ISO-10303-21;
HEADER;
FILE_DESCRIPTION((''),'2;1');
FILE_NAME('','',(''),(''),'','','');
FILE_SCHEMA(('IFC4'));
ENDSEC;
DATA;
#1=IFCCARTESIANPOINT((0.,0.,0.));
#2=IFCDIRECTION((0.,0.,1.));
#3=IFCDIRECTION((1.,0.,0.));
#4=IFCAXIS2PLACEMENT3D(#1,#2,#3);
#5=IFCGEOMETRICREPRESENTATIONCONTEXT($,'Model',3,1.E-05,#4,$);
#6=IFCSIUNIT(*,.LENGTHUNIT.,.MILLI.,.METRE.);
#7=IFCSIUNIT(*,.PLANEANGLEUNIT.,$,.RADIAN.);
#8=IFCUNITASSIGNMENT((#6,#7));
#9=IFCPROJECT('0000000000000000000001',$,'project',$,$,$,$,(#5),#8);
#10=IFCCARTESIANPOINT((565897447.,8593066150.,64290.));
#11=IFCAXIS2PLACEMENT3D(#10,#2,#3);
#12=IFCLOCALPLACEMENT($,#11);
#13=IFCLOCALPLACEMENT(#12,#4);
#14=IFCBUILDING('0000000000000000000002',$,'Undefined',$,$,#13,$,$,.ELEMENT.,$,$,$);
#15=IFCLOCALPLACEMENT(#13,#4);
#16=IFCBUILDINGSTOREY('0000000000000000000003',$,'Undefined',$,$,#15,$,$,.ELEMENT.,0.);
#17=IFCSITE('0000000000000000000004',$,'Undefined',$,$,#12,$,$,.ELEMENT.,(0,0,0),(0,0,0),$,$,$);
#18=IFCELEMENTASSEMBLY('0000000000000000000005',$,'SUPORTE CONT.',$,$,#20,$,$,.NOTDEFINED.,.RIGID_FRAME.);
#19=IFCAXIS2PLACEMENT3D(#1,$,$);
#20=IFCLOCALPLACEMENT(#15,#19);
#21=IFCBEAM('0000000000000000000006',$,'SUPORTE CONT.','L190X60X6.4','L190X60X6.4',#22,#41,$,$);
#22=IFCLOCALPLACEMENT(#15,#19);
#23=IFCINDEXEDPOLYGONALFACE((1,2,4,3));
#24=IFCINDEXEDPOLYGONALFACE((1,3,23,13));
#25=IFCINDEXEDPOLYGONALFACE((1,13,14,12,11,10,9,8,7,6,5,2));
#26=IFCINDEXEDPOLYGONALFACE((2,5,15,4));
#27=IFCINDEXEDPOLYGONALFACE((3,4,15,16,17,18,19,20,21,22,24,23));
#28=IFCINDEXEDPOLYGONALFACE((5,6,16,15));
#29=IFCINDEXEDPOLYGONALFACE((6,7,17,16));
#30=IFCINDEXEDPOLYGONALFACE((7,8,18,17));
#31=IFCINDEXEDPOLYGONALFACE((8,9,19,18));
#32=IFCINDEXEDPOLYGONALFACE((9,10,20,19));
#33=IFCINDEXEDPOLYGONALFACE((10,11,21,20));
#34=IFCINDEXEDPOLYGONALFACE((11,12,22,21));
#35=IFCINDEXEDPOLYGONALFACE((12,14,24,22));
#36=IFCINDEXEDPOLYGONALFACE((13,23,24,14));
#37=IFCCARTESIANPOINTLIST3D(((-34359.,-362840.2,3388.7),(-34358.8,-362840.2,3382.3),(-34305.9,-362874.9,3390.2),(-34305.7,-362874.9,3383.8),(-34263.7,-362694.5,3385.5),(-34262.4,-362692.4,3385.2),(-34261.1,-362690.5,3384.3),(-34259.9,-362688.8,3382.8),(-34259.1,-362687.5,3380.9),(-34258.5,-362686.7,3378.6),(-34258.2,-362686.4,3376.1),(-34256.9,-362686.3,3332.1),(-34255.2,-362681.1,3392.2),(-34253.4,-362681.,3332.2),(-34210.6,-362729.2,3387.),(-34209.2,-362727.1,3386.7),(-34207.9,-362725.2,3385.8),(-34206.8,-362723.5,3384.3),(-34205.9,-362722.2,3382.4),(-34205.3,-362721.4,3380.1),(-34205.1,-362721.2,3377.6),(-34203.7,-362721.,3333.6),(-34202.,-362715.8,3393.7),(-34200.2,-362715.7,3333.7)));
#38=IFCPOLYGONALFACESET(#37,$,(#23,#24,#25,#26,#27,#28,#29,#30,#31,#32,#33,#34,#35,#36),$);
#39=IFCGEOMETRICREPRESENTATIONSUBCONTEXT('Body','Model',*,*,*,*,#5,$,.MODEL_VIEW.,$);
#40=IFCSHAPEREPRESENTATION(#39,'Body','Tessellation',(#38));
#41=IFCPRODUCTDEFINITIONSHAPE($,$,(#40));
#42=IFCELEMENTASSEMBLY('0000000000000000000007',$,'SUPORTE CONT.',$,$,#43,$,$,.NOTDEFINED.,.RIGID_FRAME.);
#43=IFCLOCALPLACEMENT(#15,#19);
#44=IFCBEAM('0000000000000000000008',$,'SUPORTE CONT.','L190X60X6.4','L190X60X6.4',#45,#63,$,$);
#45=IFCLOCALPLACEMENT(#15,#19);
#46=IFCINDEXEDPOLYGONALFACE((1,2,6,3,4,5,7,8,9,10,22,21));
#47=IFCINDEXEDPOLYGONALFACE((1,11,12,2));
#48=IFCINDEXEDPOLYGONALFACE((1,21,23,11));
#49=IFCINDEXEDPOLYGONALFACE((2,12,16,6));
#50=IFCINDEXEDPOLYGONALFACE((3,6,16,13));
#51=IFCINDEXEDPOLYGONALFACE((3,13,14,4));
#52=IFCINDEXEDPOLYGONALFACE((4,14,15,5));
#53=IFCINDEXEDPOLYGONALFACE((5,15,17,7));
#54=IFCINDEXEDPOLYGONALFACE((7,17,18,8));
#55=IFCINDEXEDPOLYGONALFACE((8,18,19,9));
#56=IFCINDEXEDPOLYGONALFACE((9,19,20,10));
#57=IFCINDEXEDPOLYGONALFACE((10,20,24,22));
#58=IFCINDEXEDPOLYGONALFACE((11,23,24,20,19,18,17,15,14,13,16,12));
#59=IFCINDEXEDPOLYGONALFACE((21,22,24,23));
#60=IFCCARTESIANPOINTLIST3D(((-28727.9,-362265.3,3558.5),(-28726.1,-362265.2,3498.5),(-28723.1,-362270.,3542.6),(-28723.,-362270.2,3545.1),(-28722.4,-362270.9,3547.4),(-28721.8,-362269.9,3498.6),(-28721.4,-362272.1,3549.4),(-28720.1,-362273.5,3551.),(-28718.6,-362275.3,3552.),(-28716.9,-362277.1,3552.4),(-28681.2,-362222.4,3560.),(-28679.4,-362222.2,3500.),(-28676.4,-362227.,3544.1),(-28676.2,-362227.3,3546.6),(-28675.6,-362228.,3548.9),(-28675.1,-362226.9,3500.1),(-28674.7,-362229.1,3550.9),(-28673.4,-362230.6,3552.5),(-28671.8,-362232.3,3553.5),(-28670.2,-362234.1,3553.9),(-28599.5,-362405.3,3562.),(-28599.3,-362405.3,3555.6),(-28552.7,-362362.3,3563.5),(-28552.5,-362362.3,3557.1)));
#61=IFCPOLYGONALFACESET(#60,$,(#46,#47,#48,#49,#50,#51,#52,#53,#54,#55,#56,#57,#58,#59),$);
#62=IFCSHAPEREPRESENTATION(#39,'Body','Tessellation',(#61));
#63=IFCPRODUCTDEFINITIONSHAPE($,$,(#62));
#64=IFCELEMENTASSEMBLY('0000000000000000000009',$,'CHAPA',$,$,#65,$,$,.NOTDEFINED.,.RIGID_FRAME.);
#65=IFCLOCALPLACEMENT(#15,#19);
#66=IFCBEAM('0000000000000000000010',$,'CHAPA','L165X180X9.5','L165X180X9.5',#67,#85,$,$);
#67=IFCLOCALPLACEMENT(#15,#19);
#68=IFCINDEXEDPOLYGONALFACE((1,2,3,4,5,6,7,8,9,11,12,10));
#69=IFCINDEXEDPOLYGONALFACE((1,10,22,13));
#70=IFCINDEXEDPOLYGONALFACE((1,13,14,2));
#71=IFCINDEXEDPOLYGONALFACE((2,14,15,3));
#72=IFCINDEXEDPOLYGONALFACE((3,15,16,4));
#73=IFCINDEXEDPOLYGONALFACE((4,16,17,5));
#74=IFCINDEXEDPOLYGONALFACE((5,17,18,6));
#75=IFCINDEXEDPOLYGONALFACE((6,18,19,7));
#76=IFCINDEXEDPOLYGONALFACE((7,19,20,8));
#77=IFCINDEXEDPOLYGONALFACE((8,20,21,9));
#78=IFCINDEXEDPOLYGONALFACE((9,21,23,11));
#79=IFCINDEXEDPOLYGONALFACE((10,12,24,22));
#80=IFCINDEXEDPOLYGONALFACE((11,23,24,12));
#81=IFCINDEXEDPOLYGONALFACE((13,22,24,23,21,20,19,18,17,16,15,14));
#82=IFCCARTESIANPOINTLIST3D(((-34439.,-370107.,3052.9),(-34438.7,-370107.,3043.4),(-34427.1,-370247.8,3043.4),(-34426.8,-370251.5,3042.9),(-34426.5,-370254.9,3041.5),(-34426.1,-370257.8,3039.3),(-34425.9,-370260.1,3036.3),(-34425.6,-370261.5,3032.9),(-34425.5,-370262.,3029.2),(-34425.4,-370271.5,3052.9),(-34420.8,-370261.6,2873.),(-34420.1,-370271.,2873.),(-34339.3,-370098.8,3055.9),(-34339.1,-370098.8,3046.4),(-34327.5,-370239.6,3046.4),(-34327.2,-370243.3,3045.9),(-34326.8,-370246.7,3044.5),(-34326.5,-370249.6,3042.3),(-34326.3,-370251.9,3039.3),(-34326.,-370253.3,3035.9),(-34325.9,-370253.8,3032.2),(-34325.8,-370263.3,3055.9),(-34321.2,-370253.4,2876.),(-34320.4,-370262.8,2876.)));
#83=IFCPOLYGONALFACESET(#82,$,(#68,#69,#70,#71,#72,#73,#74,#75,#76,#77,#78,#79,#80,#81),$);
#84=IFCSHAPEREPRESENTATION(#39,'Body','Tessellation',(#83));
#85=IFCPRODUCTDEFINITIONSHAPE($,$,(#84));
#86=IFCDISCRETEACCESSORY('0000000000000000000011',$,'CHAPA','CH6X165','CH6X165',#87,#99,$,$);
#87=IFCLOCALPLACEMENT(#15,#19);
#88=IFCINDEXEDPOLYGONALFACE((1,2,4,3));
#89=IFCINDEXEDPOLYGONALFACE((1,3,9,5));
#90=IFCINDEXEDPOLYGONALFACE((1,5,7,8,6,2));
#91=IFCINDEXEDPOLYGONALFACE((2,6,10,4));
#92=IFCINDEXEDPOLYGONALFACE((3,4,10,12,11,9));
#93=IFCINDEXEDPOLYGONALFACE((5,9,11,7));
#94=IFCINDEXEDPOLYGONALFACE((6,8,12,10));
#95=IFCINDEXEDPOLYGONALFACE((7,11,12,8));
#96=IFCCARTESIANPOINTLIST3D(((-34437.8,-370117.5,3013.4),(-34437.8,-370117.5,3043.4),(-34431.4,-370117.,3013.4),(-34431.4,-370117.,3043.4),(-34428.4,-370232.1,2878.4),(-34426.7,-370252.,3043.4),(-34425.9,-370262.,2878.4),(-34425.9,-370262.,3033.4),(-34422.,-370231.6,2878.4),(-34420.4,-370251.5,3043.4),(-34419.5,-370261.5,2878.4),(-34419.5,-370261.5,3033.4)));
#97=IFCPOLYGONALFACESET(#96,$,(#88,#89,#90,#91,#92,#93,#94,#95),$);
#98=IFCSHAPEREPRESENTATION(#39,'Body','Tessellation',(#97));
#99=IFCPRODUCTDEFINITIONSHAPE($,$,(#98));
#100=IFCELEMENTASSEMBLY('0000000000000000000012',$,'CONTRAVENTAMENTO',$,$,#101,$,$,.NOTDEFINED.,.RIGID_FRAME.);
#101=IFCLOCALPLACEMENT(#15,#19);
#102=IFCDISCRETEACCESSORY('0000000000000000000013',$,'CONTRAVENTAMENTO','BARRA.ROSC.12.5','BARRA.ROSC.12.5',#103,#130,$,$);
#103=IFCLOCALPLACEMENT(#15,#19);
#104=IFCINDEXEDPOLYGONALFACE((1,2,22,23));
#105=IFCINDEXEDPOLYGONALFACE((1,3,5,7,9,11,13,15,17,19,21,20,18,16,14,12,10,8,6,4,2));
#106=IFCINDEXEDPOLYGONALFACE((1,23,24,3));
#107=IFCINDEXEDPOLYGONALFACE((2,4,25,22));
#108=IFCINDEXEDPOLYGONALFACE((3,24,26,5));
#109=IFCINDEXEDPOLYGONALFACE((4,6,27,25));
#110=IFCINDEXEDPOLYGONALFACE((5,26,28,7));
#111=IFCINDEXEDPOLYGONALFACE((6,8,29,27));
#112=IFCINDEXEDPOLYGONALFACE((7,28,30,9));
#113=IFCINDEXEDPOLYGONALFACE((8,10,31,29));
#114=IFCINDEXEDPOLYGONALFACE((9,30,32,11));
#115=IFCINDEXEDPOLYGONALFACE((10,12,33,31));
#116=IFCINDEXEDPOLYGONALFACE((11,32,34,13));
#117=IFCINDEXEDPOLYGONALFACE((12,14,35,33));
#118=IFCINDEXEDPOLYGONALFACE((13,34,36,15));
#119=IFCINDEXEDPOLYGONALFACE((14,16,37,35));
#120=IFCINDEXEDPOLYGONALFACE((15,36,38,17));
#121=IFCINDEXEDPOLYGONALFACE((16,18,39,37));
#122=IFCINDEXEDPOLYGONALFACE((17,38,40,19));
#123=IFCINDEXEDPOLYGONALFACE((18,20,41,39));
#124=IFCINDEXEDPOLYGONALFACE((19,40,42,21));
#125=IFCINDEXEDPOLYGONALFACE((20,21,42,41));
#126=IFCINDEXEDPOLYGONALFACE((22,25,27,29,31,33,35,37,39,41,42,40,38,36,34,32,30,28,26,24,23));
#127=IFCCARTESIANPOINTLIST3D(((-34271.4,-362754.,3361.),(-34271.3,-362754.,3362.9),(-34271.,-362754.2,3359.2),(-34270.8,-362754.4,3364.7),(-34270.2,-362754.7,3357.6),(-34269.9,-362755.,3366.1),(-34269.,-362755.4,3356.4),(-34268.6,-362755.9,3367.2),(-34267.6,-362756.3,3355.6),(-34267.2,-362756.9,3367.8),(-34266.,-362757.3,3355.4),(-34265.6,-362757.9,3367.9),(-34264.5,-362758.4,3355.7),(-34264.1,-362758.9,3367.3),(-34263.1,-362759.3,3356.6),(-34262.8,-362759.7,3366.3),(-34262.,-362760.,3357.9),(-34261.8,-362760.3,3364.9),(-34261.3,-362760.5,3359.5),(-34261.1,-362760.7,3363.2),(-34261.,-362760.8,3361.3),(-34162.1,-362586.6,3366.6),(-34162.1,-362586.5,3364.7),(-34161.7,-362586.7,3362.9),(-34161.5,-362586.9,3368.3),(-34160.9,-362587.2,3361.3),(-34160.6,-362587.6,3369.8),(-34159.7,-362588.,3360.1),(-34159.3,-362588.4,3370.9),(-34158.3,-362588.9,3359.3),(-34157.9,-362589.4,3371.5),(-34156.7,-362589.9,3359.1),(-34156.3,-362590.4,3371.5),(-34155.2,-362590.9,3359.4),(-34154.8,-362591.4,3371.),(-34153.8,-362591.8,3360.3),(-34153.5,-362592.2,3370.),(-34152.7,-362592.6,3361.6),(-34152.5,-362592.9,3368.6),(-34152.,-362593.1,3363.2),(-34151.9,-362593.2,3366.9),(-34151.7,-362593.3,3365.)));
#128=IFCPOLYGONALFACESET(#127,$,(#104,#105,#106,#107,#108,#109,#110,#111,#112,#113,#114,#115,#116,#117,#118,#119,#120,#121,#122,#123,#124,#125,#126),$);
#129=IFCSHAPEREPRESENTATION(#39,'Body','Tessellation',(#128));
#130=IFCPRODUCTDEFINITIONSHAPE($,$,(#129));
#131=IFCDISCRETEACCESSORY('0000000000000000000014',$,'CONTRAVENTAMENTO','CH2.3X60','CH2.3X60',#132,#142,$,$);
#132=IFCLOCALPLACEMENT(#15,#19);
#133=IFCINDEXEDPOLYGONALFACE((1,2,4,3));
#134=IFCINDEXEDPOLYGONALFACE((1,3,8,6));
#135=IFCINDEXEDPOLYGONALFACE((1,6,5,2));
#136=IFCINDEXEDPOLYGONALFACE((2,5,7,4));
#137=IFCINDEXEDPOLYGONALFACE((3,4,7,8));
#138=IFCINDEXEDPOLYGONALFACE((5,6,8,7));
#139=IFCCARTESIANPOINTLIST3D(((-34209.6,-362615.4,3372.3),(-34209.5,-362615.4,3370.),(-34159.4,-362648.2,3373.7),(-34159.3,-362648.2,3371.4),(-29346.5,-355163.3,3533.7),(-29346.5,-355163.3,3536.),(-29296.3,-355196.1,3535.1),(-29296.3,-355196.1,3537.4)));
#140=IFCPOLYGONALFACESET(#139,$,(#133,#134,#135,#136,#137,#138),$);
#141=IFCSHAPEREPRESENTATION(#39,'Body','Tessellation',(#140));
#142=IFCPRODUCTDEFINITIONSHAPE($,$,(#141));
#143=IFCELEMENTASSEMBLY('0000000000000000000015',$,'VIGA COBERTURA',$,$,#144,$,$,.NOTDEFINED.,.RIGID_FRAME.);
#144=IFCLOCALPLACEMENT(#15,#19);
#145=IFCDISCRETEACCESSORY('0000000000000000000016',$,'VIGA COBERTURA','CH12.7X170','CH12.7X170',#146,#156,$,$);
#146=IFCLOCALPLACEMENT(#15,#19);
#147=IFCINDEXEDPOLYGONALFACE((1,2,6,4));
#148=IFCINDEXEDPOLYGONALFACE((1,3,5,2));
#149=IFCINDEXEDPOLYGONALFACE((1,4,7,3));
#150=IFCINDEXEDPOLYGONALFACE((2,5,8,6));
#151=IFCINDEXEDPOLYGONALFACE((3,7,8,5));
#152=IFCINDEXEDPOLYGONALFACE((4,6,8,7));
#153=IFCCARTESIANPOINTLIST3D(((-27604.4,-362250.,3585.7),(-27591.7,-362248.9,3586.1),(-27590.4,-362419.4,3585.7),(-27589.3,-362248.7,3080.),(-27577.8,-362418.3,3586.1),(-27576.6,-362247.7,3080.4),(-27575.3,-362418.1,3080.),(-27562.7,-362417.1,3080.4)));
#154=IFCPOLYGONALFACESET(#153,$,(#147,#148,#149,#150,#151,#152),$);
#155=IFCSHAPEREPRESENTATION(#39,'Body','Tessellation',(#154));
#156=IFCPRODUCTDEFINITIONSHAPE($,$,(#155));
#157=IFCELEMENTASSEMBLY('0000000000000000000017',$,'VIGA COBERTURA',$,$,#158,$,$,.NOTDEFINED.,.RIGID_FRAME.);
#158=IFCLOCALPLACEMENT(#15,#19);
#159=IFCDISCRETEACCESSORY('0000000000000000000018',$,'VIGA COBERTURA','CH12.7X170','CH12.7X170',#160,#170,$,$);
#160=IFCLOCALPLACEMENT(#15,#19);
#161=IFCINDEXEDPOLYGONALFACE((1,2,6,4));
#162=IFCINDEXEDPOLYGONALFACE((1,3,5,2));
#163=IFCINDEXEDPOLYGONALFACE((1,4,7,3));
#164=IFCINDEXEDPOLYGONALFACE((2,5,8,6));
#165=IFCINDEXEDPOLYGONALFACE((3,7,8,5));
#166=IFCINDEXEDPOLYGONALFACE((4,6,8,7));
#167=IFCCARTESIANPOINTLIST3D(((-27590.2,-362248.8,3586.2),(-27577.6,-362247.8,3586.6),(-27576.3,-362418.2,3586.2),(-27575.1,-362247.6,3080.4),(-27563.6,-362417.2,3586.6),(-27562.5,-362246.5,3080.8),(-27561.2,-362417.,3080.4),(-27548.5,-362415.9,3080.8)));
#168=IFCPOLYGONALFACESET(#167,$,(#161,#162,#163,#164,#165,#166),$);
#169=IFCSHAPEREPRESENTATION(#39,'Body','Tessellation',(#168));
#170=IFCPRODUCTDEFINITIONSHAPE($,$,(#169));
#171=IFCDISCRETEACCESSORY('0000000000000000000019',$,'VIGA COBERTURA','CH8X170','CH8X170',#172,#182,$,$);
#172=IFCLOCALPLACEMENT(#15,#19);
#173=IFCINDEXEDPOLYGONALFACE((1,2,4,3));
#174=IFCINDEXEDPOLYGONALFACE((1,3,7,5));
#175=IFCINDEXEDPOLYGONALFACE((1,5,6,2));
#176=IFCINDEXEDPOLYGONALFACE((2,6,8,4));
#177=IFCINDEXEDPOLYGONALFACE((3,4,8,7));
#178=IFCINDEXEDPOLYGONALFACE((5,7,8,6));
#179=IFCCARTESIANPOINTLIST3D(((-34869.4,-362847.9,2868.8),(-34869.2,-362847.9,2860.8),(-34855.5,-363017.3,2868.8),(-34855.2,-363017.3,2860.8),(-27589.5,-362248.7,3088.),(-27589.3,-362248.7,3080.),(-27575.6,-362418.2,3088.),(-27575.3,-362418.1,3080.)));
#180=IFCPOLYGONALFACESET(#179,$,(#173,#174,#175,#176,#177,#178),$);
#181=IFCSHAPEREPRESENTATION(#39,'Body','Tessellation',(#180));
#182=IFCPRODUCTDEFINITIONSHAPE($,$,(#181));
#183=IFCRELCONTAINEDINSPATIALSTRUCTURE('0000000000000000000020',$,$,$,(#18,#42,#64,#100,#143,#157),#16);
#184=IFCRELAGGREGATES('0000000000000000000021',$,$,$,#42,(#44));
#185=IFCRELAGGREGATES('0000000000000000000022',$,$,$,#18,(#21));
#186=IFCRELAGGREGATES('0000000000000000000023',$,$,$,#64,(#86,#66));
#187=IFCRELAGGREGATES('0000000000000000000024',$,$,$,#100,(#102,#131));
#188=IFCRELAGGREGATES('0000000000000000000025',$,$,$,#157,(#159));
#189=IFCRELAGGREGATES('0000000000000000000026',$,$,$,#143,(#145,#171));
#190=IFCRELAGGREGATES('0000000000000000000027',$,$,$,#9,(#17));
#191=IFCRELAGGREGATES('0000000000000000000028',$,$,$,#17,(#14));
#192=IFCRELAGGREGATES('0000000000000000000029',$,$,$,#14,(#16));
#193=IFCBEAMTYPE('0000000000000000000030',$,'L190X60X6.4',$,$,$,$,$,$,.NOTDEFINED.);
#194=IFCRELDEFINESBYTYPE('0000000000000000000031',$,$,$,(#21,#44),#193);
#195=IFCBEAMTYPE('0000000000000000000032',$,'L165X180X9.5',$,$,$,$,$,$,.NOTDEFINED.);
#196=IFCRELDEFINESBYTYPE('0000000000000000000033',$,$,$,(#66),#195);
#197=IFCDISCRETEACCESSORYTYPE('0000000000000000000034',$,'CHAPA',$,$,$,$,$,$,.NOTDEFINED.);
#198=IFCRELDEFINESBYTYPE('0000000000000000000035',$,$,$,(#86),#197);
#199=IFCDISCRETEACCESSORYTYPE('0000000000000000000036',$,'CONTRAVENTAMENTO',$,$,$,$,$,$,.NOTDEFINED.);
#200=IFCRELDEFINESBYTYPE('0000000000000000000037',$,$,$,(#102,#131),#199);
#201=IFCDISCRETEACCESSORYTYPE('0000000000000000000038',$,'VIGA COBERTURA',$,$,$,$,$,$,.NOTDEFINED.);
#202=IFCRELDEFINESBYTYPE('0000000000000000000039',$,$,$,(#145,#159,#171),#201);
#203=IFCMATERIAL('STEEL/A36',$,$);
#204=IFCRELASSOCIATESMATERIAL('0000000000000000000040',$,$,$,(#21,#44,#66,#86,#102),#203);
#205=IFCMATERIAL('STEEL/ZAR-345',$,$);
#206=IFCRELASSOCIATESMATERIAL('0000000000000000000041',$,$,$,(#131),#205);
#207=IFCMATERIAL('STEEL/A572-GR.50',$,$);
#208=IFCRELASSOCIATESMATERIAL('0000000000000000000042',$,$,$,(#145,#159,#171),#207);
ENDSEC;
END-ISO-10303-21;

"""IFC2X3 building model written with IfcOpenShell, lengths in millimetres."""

from ifc_helpers import new_model, si_unit, frame, origin_with_axes, origin_2d_with_axis, place, context, subcontext, project, spatial, polyline, rectangle, circle, l_section, outline, extrude, material, type_object, element, aggregate, save


model = new_model("IFC2X3")

# Units and contexts
model_context = context("Model", 3, precision=1e-05, world=origin_with_axes())
body_context = subcontext(model_context, "Body", "Model", "MODEL_VIEW")
ifc_project = project(units=[si_unit("LENGTHUNIT", "METRE", prefix="MILLI"), si_unit("PLANEANGLEUNIT", "RADIAN")], contexts=[model_context])

# Site, building, storey
site_placement = place(None, frame((565897447.0, 8593066150.0, 64290.0), z_axis=(0.0, 0.0, 1.0), x_axis=(1.0, 0.0, 0.0)))
site = spatial("IfcSite", under=ifc_project, at=site_placement, Name="Undefined", CompositionType="ELEMENT", RefLatitude=(0, 0, 0), RefLongitude=(0, 0, 0))
building_placement = place(site_placement, origin_with_axes())
building = spatial("IfcBuilding", under=site, at=building_placement, Name="Undefined", CompositionType="ELEMENT")
storey_placement = place(building_placement, origin_with_axes())
storey = spatial("IfcBuildingStorey", under=building, at=storey_placement, Name="Undefined", CompositionType="ELEMENT", Elevation=0.0)

# Element assemblies, beams
ifc_material_1 = material(Name="STEEL/A36")
assembly_1_placement = place(storey_placement, origin_with_axes())
assembly_1 = element("IfcElementAssembly", 1, at=assembly_1_placement, inside=storey, Name="SUPORTE CONT.", AssemblyPlace="NOTDEFINED", PredefinedType="RIGID_FRAME")
beam_type_1 = type_object("IfcBeamType", Name="L190X60X6.4", PredefinedType="NOTDEFINED")
beam_1_placement = place(assembly_1_placement, frame((-34306.2, -362760.6, 3360.5), z_axis=(-0.546411, -0.837315, -0.018398), x_axis=(0.836984, -0.546715, 0.02368)))
beam_1 = element("IfcBeam", 2, at=beam_1_placement, type_object=beam_type_1, material=ifc_material_1, Name="SUPORTE CONT.", Description="L190X60X6.4", ObjectType="L190X60X6.4", context=body_context, shape_type="SweptSolid", body=[
    extrude(l_section(Depth=190.0, Width=60.0, Thickness=6.4, FilletRadius=9.6, at=origin_2d_with_axis()), frame((63.5, 0.0, 0.0), z_axis=(-1.0, 0.0, 0.0), x_axis=(0.0, -1.0, 0.0)), (0.0, 0.0, 1.0), 63.5),
])
assembly_2_placement = place(storey_placement, origin_with_axes())
assembly_2 = element("IfcElementAssembly", 3, at=assembly_2_placement, inside=storey, Name="SUPORTE CONT.", AssemblyPlace="NOTDEFINED", PredefinedType="RIGID_FRAME")
beam_2_placement = place(assembly_2_placement, frame((-28662.8, -362335.2, 3530.2), z_axis=(0.675958, -0.736711, 0.018398), x_axis=(0.736334, 0.676203, 0.02368)))
beam_2 = element("IfcBeam", 4, at=beam_2_placement, type_object=beam_type_1, material=ifc_material_1, Name="SUPORTE CONT.", Description="L190X60X6.4", ObjectType="L190X60X6.4", context=body_context, shape_type="SweptSolid", body=[
    extrude(l_section(Depth=190.0, Width=60.0, Thickness=6.4, FilletRadius=9.6, at=origin_2d_with_axis()), frame((63.5, 0.0, 0.0), z_axis=(-1.0, 0.0, 0.0), x_axis=(0.0, -1.0, 0.0)), (0.0, 0.0, 1.0), 63.5),
])
aggregate(assembly_2, [beam_2])
assembly_3_placement = place(storey_placement, origin_with_axes())
assembly_3 = element("IfcElementAssembly", 5, at=assembly_3_placement, inside=storey, Name="CHAPA", AssemblyPlace="NOTDEFINED", PredefinedType="RIGID_FRAME")
beam_type_2 = type_object("IfcBeamType", Name="L165X180X9.5", PredefinedType="NOTDEFINED")
beam_3_placement = place(assembly_3_placement, frame((-34329.9, -370180.8, 2966.0), z_axis=(-0.082025, 0.99663, 0.0), x_axis=(-0.996182, -0.081989, -0.029987)))
beam_3 = element("IfcBeam", 6, at=beam_3_placement, type_object=beam_type_2, material=ifc_material_1, Name="CHAPA", Description="L165X180X9.5", ObjectType="L165X180X9.5", context=body_context, shape_type="SweptSolid", body=[
    extrude(l_section(Depth=165.0, Width=180.0, Thickness=9.5, FilletRadius=14.2, at=origin_2d_with_axis()), frame((100.0, 0.0, 0.0), z_axis=(-1.0, 0.0, 0.0), x_axis=(0.0, -1.0, 0.0)), (0.0, 0.0, 1.0), 100.0),
])

# Discrete accessory
discrete_accessory_type_1 = type_object("IfcDiscreteAccessoryType", Name="CHAPA")
aggregate(assembly_1, [beam_1])
discrete_accessory_1_placement = place(assembly_3_placement, frame((-34422.7, -370261.7, 3043.4), z_axis=(0.99663, 0.082025, -0.000004), x_axis=(-0.000004, 0.0, -1.0)))
discrete_accessory_1 = element("IfcDiscreteAccessory", 7, at=discrete_accessory_1_placement, type_object=discrete_accessory_type_1, material=ifc_material_1, Name="CHAPA", Description="CH6X165", ObjectType="CH6X165", context=body_context, shape_type="SweptSolid", body=[
    extrude(outline(polyline([(0.0, 10.0), (10.0, 0.0), (165.0, 0.0), (165.0, 30.0), (30.0, 145.0), (0.0, 145.0), (0.0, 10.0)])), frame((0.0, 0.0, -3.2), z_axis=(0.0, 0.0, 1.0), x_axis=(1.0, 0.0, 0.0)), (0.0, 0.0, 1.0), 6.4),
])
aggregate(assembly_3, [discrete_accessory_1, beam_3])

# Element assembly, discrete accessories
assembly_4_placement = place(storey_placement, origin_with_axes())
assembly_4 = element("IfcElementAssembly", 8, at=assembly_4_placement, inside=storey, Name="CONTRAVENTAMENTO", AssemblyPlace="NOTDEFINED", PredefinedType="RIGID_FRAME")
discrete_accessory_type_2 = type_object("IfcDiscreteAccessoryType", Name="CONTRAVENTAMENTO")
discrete_accessory_2_placement = place(assembly_4_placement, frame((-34266.2, -362757.4, 3361.7), z_axis=(0.836984, -0.546715, 0.02368), x_axis=(0.546411, 0.837315, 0.018398)))
discrete_accessory_2 = element("IfcDiscreteAccessory", 9, at=discrete_accessory_2_placement, type_object=discrete_accessory_type_2, material=ifc_material_1, Name="CONTRAVENTAMENTO", Description="BARRA.ROSC.12.5", ObjectType="BARRA.ROSC.12.5", context=body_context, shape_type="SweptSolid", body=[
    extrude(circle(Radius=6.2, at=origin_2d_with_axis()), frame((200.0, 0.0, 0.0), z_axis=(-1.0, 0.0, 0.0), x_axis=(0.0, -1.0, 0.0)), (0.0, 0.0, 1.0), 200.0),
])
ifc_material_2 = material(Name="STEEL/ZAR-345")
discrete_accessory_3_placement = place(assembly_4_placement, frame((-34184.5, -362631.8, 3371.8), z_axis=(0.029885, 0.00246, -0.99955), x_axis=(0.546411, 0.837315, 0.018398)))
discrete_accessory_3 = element("IfcDiscreteAccessory", 10, at=discrete_accessory_3_placement, type_object=discrete_accessory_type_2, material=ifc_material_2, Name="CONTRAVENTAMENTO", Description="CH2.3X60", ObjectType="CH2.3X60", context=body_context, shape_type="SweptSolid", body=[
    extrude(outline(polyline([(8900.0, -30.0), (0.0, -30.0), (0.0, 30.0), (8900.0, 30.0), (8900.0, -30.0)])), frame((0.0, 0.0, -1.1), z_axis=(0.0, 0.0, 1.0), x_axis=(1.0, 0.0, 0.0)), (0.0, 0.0, 1.0), 2.3),
])
aggregate(assembly_4, [discrete_accessory_2, discrete_accessory_3])

# Element assemblies, discrete accessories
assembly_5_placement = place(storey_placement, origin_with_axes())
assembly_5 = element("IfcElementAssembly", 11, at=assembly_5_placement, inside=storey, Name="VIGA COBERTURA", AssemblyPlace="NOTDEFINED", PredefinedType="RIGID_FRAME")
ifc_material_3 = material(Name="STEEL/A572-GR.50")
discrete_accessory_type_3 = type_object("IfcDiscreteAccessoryType", Name="VIGA COBERTURA")
discrete_accessory_4_placement = place(assembly_5_placement, frame((-27591.1, -362334.2, 3585.9), z_axis=(0.082025, -0.99663, 0.0), x_axis=(0.029885, 0.00246, -0.99955)))
discrete_accessory_4 = element("IfcDiscreteAccessory", 12, at=discrete_accessory_4_placement, type_object=discrete_accessory_type_3, material=ifc_material_3, Name="VIGA COBERTURA", Description="CH12.7X170", ObjectType="CH12.7X170", context=body_context, shape_type="SweptSolid", body=[
    extrude(rectangle(XDim=12.7, YDim=170.0, at=origin_2d_with_axis()), frame((506.0, 0.0, 0.0), z_axis=(-1.0, 0.0, 0.0), x_axis=(0.0, -1.0, 0.0)), (0.0, 0.0, 1.0), 506.0),
])
assembly_6_placement = place(storey_placement, origin_with_axes())
assembly_6 = element("IfcElementAssembly", 13, at=assembly_6_placement, inside=storey, Name="VIGA COBERTURA", AssemblyPlace="NOTDEFINED", PredefinedType="RIGID_FRAME")
discrete_accessory_5_placement = place(assembly_6_placement, frame((-27576.9, -362333.0, 3586.4), z_axis=(0.082025, -0.99663, 0.0), x_axis=(0.029885, 0.00246, -0.99955)))
discrete_accessory_5 = element("IfcDiscreteAccessory", 14, at=discrete_accessory_5_placement, type_object=discrete_accessory_type_3, material=ifc_material_3, Name="VIGA COBERTURA", Description="CH12.7X170", ObjectType="CH12.7X170", context=body_context, shape_type="SweptSolid", body=[
    extrude(rectangle(XDim=12.7, YDim=170.0, at=origin_2d_with_axis()), frame((506.0, 0.0, 0.0), z_axis=(-1.0, 0.0, 0.0), x_axis=(0.0, -1.0, 0.0)), (0.0, 0.0, 1.0), 506.0),
])
aggregate(assembly_6, [discrete_accessory_5])

# Discrete accessory
discrete_accessory_6_placement = place(assembly_5_placement, frame((-27582.4, -362333.4, 3084.0), z_axis=(0.029885, 0.00246, -0.99955), x_axis=(-0.996182, -0.081989, -0.029987)))
discrete_accessory_6 = element("IfcDiscreteAccessory", 15, at=discrete_accessory_6_placement, type_object=discrete_accessory_type_3, material=ifc_material_3, Name="VIGA COBERTURA", Description="CH8X170", ObjectType="CH8X170", context=body_context, shape_type="SweptSolid", body=[
    extrude(outline(polyline([(7307.8, 85.0), (7307.8, -85.0), (0.0, -85.0), (0.0, 85.0), (7307.8, 85.0)])), frame((0.0, 0.0, -4.0), z_axis=(0.0, 0.0, 1.0), x_axis=(1.0, 0.0, 0.0)), (0.0, 0.0, 1.0), 8.0),
])
aggregate(assembly_5, [discrete_accessory_4, discrete_accessory_6])

save(model, "model.ifc")
